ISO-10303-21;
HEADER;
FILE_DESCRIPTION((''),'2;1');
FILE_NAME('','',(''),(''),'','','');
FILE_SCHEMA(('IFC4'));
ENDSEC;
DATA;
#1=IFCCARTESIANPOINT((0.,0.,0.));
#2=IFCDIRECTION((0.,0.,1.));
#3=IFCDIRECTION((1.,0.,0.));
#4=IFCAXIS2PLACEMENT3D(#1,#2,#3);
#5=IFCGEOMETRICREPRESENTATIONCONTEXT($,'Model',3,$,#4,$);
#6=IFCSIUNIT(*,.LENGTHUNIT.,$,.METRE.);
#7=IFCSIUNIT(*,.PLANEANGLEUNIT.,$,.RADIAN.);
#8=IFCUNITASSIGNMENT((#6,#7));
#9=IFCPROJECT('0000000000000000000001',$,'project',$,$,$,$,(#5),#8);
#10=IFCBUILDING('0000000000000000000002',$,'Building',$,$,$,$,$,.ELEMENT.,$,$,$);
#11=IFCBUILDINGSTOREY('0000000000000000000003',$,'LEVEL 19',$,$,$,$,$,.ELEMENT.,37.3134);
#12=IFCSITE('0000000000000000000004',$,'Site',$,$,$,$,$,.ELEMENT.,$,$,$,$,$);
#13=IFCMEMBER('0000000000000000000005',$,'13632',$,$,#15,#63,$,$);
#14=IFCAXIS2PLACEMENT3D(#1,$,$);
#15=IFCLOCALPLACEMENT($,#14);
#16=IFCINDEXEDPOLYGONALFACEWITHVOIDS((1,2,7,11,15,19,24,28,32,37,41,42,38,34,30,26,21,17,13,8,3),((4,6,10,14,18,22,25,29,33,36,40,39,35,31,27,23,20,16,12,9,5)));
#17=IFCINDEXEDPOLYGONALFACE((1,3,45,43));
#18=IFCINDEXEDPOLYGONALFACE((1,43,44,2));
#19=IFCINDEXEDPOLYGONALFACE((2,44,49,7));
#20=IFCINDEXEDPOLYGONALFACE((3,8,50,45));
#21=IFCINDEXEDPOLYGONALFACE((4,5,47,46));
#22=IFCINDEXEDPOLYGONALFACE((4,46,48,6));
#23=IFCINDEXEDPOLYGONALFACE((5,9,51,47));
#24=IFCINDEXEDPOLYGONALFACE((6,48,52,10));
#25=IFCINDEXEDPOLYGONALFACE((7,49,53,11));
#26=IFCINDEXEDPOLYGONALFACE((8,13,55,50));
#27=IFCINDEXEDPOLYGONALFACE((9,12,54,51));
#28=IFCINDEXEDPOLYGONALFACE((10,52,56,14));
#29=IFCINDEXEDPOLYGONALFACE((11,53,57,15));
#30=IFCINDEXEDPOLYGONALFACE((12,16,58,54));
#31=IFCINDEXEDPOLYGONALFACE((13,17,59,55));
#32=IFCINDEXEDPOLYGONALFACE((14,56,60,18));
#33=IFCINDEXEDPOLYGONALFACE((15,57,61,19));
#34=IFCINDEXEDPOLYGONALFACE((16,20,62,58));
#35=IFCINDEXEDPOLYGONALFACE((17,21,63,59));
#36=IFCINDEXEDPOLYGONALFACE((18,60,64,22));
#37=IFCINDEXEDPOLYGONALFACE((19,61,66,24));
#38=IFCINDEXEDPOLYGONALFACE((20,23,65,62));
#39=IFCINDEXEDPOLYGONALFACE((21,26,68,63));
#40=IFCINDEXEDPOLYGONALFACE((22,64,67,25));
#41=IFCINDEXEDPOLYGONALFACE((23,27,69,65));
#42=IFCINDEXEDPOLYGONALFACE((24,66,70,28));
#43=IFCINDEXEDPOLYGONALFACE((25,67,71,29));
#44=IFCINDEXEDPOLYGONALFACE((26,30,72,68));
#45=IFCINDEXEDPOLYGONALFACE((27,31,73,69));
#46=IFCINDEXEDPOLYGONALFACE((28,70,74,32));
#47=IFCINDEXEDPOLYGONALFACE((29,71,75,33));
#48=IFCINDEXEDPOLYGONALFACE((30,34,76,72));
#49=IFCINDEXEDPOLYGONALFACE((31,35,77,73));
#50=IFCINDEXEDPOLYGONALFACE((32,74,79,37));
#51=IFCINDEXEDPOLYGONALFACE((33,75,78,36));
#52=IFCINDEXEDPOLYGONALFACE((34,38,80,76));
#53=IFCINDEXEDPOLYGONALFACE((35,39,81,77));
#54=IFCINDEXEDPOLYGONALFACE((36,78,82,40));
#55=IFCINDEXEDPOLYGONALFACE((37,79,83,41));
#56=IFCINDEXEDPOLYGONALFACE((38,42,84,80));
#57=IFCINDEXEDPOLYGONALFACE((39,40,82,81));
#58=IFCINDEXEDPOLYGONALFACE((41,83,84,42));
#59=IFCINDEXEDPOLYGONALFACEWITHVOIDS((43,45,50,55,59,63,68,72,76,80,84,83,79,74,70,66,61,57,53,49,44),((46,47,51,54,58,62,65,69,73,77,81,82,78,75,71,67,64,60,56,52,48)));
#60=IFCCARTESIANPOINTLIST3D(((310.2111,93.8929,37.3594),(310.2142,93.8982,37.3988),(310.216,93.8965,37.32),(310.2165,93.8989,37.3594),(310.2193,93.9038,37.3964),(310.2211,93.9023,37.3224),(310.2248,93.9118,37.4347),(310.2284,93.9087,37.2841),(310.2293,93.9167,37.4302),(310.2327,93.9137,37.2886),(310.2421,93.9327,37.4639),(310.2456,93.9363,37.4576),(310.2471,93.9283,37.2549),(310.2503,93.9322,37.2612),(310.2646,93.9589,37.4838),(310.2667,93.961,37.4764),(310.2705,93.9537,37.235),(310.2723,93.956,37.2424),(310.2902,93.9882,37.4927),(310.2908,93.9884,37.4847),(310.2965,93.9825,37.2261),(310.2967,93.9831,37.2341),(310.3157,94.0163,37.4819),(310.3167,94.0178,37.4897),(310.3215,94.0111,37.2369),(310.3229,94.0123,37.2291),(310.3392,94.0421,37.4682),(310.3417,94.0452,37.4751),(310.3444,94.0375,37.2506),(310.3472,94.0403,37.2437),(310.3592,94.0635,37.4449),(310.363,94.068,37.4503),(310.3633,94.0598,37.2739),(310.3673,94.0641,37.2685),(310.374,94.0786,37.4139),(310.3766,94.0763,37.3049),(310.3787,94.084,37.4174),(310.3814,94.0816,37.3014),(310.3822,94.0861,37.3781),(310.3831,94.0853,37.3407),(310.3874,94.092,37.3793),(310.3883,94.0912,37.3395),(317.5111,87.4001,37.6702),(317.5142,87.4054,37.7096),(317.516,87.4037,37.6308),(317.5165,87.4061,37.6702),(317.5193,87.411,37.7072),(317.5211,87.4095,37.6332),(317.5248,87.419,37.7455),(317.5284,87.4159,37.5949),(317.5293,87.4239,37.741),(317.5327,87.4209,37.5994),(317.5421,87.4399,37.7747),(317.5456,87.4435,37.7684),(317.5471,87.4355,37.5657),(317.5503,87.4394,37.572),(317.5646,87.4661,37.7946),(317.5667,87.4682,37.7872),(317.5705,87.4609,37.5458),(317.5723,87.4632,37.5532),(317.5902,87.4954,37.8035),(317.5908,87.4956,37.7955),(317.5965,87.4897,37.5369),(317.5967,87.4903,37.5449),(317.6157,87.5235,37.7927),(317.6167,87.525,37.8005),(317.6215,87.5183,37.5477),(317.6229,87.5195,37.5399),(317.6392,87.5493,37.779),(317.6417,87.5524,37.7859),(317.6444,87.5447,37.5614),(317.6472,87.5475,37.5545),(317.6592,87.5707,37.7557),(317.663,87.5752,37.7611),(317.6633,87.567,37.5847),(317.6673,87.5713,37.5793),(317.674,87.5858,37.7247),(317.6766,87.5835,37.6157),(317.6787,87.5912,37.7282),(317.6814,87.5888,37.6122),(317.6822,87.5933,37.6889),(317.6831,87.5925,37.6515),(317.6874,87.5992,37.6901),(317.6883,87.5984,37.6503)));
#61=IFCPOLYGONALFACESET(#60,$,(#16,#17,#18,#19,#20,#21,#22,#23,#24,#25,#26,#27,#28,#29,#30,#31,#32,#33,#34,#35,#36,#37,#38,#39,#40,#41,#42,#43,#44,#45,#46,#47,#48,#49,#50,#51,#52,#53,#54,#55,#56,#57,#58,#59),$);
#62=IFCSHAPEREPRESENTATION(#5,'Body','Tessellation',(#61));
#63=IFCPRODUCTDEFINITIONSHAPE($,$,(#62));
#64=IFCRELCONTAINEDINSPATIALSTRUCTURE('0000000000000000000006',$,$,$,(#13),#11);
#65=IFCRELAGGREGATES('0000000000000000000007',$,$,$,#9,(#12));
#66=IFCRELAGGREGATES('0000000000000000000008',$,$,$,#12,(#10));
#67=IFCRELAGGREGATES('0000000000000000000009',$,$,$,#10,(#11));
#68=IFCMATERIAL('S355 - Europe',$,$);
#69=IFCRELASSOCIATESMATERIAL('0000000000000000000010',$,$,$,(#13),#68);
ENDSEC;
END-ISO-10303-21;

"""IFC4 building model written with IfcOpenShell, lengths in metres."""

from ifc_helpers import new_model, si_unit, frame, origin_with_axes, origin_2d_with_axis, place, context, project, spatial, hollow_circle, extrude, material, material_profile, profile_set, profile_usage, element, save


model = new_model("IFC4")

# Units and contexts
model_context = context("Model", 3, world=origin_with_axes())
ifc_project = project(units=[si_unit("LENGTHUNIT", "METRE"), si_unit("PLANEANGLEUNIT", "RADIAN")], contexts=[model_context])

# Site, building, storey
site = spatial("IfcSite", under=ifc_project, Name="Site", CompositionType="ELEMENT")
building = spatial("IfcBuilding", under=site, Name="Building", CompositionType="ELEMENT")
storey = spatial("IfcBuildingStorey", under=building, Name="LEVEL 19", CompositionType="ELEMENT", Elevation=37.3134)

# Shared definitions
ifc_material = material(Name="S355 - Europe")

# Member
ifc_material_profile_1 = material_profile(ifc_material, hollow_circle(Radius=0.1337, WallThickness=0.008, at=origin_2d_with_axis()))
ifc_profile_set_1 = profile_set([ifc_material_profile_1])
ifc_profile_usage_1 = profile_usage(ifc_profile_set_1, cardinal=10)
member_1_placement = place(None, frame((317.6, 87.5, 37.6702), z_axis=(-0.746833, 0.664251, -0.031797), x_axis=(-0.664364, -0.747409, 0.0)))
element("IfcMember", 1, at=member_1_placement, inside=storey, material=ifc_profile_usage_1, Name="13632", context=model_context, shape_type="SweptSolid", body=[
    extrude(hollow_circle(Radius=0.1337, WallThickness=0.008, at=origin_2d_with_axis()), origin_with_axes(), (0.0, 0.0, 1.0), 9.7746),
])

save(model, "model.ifc")
